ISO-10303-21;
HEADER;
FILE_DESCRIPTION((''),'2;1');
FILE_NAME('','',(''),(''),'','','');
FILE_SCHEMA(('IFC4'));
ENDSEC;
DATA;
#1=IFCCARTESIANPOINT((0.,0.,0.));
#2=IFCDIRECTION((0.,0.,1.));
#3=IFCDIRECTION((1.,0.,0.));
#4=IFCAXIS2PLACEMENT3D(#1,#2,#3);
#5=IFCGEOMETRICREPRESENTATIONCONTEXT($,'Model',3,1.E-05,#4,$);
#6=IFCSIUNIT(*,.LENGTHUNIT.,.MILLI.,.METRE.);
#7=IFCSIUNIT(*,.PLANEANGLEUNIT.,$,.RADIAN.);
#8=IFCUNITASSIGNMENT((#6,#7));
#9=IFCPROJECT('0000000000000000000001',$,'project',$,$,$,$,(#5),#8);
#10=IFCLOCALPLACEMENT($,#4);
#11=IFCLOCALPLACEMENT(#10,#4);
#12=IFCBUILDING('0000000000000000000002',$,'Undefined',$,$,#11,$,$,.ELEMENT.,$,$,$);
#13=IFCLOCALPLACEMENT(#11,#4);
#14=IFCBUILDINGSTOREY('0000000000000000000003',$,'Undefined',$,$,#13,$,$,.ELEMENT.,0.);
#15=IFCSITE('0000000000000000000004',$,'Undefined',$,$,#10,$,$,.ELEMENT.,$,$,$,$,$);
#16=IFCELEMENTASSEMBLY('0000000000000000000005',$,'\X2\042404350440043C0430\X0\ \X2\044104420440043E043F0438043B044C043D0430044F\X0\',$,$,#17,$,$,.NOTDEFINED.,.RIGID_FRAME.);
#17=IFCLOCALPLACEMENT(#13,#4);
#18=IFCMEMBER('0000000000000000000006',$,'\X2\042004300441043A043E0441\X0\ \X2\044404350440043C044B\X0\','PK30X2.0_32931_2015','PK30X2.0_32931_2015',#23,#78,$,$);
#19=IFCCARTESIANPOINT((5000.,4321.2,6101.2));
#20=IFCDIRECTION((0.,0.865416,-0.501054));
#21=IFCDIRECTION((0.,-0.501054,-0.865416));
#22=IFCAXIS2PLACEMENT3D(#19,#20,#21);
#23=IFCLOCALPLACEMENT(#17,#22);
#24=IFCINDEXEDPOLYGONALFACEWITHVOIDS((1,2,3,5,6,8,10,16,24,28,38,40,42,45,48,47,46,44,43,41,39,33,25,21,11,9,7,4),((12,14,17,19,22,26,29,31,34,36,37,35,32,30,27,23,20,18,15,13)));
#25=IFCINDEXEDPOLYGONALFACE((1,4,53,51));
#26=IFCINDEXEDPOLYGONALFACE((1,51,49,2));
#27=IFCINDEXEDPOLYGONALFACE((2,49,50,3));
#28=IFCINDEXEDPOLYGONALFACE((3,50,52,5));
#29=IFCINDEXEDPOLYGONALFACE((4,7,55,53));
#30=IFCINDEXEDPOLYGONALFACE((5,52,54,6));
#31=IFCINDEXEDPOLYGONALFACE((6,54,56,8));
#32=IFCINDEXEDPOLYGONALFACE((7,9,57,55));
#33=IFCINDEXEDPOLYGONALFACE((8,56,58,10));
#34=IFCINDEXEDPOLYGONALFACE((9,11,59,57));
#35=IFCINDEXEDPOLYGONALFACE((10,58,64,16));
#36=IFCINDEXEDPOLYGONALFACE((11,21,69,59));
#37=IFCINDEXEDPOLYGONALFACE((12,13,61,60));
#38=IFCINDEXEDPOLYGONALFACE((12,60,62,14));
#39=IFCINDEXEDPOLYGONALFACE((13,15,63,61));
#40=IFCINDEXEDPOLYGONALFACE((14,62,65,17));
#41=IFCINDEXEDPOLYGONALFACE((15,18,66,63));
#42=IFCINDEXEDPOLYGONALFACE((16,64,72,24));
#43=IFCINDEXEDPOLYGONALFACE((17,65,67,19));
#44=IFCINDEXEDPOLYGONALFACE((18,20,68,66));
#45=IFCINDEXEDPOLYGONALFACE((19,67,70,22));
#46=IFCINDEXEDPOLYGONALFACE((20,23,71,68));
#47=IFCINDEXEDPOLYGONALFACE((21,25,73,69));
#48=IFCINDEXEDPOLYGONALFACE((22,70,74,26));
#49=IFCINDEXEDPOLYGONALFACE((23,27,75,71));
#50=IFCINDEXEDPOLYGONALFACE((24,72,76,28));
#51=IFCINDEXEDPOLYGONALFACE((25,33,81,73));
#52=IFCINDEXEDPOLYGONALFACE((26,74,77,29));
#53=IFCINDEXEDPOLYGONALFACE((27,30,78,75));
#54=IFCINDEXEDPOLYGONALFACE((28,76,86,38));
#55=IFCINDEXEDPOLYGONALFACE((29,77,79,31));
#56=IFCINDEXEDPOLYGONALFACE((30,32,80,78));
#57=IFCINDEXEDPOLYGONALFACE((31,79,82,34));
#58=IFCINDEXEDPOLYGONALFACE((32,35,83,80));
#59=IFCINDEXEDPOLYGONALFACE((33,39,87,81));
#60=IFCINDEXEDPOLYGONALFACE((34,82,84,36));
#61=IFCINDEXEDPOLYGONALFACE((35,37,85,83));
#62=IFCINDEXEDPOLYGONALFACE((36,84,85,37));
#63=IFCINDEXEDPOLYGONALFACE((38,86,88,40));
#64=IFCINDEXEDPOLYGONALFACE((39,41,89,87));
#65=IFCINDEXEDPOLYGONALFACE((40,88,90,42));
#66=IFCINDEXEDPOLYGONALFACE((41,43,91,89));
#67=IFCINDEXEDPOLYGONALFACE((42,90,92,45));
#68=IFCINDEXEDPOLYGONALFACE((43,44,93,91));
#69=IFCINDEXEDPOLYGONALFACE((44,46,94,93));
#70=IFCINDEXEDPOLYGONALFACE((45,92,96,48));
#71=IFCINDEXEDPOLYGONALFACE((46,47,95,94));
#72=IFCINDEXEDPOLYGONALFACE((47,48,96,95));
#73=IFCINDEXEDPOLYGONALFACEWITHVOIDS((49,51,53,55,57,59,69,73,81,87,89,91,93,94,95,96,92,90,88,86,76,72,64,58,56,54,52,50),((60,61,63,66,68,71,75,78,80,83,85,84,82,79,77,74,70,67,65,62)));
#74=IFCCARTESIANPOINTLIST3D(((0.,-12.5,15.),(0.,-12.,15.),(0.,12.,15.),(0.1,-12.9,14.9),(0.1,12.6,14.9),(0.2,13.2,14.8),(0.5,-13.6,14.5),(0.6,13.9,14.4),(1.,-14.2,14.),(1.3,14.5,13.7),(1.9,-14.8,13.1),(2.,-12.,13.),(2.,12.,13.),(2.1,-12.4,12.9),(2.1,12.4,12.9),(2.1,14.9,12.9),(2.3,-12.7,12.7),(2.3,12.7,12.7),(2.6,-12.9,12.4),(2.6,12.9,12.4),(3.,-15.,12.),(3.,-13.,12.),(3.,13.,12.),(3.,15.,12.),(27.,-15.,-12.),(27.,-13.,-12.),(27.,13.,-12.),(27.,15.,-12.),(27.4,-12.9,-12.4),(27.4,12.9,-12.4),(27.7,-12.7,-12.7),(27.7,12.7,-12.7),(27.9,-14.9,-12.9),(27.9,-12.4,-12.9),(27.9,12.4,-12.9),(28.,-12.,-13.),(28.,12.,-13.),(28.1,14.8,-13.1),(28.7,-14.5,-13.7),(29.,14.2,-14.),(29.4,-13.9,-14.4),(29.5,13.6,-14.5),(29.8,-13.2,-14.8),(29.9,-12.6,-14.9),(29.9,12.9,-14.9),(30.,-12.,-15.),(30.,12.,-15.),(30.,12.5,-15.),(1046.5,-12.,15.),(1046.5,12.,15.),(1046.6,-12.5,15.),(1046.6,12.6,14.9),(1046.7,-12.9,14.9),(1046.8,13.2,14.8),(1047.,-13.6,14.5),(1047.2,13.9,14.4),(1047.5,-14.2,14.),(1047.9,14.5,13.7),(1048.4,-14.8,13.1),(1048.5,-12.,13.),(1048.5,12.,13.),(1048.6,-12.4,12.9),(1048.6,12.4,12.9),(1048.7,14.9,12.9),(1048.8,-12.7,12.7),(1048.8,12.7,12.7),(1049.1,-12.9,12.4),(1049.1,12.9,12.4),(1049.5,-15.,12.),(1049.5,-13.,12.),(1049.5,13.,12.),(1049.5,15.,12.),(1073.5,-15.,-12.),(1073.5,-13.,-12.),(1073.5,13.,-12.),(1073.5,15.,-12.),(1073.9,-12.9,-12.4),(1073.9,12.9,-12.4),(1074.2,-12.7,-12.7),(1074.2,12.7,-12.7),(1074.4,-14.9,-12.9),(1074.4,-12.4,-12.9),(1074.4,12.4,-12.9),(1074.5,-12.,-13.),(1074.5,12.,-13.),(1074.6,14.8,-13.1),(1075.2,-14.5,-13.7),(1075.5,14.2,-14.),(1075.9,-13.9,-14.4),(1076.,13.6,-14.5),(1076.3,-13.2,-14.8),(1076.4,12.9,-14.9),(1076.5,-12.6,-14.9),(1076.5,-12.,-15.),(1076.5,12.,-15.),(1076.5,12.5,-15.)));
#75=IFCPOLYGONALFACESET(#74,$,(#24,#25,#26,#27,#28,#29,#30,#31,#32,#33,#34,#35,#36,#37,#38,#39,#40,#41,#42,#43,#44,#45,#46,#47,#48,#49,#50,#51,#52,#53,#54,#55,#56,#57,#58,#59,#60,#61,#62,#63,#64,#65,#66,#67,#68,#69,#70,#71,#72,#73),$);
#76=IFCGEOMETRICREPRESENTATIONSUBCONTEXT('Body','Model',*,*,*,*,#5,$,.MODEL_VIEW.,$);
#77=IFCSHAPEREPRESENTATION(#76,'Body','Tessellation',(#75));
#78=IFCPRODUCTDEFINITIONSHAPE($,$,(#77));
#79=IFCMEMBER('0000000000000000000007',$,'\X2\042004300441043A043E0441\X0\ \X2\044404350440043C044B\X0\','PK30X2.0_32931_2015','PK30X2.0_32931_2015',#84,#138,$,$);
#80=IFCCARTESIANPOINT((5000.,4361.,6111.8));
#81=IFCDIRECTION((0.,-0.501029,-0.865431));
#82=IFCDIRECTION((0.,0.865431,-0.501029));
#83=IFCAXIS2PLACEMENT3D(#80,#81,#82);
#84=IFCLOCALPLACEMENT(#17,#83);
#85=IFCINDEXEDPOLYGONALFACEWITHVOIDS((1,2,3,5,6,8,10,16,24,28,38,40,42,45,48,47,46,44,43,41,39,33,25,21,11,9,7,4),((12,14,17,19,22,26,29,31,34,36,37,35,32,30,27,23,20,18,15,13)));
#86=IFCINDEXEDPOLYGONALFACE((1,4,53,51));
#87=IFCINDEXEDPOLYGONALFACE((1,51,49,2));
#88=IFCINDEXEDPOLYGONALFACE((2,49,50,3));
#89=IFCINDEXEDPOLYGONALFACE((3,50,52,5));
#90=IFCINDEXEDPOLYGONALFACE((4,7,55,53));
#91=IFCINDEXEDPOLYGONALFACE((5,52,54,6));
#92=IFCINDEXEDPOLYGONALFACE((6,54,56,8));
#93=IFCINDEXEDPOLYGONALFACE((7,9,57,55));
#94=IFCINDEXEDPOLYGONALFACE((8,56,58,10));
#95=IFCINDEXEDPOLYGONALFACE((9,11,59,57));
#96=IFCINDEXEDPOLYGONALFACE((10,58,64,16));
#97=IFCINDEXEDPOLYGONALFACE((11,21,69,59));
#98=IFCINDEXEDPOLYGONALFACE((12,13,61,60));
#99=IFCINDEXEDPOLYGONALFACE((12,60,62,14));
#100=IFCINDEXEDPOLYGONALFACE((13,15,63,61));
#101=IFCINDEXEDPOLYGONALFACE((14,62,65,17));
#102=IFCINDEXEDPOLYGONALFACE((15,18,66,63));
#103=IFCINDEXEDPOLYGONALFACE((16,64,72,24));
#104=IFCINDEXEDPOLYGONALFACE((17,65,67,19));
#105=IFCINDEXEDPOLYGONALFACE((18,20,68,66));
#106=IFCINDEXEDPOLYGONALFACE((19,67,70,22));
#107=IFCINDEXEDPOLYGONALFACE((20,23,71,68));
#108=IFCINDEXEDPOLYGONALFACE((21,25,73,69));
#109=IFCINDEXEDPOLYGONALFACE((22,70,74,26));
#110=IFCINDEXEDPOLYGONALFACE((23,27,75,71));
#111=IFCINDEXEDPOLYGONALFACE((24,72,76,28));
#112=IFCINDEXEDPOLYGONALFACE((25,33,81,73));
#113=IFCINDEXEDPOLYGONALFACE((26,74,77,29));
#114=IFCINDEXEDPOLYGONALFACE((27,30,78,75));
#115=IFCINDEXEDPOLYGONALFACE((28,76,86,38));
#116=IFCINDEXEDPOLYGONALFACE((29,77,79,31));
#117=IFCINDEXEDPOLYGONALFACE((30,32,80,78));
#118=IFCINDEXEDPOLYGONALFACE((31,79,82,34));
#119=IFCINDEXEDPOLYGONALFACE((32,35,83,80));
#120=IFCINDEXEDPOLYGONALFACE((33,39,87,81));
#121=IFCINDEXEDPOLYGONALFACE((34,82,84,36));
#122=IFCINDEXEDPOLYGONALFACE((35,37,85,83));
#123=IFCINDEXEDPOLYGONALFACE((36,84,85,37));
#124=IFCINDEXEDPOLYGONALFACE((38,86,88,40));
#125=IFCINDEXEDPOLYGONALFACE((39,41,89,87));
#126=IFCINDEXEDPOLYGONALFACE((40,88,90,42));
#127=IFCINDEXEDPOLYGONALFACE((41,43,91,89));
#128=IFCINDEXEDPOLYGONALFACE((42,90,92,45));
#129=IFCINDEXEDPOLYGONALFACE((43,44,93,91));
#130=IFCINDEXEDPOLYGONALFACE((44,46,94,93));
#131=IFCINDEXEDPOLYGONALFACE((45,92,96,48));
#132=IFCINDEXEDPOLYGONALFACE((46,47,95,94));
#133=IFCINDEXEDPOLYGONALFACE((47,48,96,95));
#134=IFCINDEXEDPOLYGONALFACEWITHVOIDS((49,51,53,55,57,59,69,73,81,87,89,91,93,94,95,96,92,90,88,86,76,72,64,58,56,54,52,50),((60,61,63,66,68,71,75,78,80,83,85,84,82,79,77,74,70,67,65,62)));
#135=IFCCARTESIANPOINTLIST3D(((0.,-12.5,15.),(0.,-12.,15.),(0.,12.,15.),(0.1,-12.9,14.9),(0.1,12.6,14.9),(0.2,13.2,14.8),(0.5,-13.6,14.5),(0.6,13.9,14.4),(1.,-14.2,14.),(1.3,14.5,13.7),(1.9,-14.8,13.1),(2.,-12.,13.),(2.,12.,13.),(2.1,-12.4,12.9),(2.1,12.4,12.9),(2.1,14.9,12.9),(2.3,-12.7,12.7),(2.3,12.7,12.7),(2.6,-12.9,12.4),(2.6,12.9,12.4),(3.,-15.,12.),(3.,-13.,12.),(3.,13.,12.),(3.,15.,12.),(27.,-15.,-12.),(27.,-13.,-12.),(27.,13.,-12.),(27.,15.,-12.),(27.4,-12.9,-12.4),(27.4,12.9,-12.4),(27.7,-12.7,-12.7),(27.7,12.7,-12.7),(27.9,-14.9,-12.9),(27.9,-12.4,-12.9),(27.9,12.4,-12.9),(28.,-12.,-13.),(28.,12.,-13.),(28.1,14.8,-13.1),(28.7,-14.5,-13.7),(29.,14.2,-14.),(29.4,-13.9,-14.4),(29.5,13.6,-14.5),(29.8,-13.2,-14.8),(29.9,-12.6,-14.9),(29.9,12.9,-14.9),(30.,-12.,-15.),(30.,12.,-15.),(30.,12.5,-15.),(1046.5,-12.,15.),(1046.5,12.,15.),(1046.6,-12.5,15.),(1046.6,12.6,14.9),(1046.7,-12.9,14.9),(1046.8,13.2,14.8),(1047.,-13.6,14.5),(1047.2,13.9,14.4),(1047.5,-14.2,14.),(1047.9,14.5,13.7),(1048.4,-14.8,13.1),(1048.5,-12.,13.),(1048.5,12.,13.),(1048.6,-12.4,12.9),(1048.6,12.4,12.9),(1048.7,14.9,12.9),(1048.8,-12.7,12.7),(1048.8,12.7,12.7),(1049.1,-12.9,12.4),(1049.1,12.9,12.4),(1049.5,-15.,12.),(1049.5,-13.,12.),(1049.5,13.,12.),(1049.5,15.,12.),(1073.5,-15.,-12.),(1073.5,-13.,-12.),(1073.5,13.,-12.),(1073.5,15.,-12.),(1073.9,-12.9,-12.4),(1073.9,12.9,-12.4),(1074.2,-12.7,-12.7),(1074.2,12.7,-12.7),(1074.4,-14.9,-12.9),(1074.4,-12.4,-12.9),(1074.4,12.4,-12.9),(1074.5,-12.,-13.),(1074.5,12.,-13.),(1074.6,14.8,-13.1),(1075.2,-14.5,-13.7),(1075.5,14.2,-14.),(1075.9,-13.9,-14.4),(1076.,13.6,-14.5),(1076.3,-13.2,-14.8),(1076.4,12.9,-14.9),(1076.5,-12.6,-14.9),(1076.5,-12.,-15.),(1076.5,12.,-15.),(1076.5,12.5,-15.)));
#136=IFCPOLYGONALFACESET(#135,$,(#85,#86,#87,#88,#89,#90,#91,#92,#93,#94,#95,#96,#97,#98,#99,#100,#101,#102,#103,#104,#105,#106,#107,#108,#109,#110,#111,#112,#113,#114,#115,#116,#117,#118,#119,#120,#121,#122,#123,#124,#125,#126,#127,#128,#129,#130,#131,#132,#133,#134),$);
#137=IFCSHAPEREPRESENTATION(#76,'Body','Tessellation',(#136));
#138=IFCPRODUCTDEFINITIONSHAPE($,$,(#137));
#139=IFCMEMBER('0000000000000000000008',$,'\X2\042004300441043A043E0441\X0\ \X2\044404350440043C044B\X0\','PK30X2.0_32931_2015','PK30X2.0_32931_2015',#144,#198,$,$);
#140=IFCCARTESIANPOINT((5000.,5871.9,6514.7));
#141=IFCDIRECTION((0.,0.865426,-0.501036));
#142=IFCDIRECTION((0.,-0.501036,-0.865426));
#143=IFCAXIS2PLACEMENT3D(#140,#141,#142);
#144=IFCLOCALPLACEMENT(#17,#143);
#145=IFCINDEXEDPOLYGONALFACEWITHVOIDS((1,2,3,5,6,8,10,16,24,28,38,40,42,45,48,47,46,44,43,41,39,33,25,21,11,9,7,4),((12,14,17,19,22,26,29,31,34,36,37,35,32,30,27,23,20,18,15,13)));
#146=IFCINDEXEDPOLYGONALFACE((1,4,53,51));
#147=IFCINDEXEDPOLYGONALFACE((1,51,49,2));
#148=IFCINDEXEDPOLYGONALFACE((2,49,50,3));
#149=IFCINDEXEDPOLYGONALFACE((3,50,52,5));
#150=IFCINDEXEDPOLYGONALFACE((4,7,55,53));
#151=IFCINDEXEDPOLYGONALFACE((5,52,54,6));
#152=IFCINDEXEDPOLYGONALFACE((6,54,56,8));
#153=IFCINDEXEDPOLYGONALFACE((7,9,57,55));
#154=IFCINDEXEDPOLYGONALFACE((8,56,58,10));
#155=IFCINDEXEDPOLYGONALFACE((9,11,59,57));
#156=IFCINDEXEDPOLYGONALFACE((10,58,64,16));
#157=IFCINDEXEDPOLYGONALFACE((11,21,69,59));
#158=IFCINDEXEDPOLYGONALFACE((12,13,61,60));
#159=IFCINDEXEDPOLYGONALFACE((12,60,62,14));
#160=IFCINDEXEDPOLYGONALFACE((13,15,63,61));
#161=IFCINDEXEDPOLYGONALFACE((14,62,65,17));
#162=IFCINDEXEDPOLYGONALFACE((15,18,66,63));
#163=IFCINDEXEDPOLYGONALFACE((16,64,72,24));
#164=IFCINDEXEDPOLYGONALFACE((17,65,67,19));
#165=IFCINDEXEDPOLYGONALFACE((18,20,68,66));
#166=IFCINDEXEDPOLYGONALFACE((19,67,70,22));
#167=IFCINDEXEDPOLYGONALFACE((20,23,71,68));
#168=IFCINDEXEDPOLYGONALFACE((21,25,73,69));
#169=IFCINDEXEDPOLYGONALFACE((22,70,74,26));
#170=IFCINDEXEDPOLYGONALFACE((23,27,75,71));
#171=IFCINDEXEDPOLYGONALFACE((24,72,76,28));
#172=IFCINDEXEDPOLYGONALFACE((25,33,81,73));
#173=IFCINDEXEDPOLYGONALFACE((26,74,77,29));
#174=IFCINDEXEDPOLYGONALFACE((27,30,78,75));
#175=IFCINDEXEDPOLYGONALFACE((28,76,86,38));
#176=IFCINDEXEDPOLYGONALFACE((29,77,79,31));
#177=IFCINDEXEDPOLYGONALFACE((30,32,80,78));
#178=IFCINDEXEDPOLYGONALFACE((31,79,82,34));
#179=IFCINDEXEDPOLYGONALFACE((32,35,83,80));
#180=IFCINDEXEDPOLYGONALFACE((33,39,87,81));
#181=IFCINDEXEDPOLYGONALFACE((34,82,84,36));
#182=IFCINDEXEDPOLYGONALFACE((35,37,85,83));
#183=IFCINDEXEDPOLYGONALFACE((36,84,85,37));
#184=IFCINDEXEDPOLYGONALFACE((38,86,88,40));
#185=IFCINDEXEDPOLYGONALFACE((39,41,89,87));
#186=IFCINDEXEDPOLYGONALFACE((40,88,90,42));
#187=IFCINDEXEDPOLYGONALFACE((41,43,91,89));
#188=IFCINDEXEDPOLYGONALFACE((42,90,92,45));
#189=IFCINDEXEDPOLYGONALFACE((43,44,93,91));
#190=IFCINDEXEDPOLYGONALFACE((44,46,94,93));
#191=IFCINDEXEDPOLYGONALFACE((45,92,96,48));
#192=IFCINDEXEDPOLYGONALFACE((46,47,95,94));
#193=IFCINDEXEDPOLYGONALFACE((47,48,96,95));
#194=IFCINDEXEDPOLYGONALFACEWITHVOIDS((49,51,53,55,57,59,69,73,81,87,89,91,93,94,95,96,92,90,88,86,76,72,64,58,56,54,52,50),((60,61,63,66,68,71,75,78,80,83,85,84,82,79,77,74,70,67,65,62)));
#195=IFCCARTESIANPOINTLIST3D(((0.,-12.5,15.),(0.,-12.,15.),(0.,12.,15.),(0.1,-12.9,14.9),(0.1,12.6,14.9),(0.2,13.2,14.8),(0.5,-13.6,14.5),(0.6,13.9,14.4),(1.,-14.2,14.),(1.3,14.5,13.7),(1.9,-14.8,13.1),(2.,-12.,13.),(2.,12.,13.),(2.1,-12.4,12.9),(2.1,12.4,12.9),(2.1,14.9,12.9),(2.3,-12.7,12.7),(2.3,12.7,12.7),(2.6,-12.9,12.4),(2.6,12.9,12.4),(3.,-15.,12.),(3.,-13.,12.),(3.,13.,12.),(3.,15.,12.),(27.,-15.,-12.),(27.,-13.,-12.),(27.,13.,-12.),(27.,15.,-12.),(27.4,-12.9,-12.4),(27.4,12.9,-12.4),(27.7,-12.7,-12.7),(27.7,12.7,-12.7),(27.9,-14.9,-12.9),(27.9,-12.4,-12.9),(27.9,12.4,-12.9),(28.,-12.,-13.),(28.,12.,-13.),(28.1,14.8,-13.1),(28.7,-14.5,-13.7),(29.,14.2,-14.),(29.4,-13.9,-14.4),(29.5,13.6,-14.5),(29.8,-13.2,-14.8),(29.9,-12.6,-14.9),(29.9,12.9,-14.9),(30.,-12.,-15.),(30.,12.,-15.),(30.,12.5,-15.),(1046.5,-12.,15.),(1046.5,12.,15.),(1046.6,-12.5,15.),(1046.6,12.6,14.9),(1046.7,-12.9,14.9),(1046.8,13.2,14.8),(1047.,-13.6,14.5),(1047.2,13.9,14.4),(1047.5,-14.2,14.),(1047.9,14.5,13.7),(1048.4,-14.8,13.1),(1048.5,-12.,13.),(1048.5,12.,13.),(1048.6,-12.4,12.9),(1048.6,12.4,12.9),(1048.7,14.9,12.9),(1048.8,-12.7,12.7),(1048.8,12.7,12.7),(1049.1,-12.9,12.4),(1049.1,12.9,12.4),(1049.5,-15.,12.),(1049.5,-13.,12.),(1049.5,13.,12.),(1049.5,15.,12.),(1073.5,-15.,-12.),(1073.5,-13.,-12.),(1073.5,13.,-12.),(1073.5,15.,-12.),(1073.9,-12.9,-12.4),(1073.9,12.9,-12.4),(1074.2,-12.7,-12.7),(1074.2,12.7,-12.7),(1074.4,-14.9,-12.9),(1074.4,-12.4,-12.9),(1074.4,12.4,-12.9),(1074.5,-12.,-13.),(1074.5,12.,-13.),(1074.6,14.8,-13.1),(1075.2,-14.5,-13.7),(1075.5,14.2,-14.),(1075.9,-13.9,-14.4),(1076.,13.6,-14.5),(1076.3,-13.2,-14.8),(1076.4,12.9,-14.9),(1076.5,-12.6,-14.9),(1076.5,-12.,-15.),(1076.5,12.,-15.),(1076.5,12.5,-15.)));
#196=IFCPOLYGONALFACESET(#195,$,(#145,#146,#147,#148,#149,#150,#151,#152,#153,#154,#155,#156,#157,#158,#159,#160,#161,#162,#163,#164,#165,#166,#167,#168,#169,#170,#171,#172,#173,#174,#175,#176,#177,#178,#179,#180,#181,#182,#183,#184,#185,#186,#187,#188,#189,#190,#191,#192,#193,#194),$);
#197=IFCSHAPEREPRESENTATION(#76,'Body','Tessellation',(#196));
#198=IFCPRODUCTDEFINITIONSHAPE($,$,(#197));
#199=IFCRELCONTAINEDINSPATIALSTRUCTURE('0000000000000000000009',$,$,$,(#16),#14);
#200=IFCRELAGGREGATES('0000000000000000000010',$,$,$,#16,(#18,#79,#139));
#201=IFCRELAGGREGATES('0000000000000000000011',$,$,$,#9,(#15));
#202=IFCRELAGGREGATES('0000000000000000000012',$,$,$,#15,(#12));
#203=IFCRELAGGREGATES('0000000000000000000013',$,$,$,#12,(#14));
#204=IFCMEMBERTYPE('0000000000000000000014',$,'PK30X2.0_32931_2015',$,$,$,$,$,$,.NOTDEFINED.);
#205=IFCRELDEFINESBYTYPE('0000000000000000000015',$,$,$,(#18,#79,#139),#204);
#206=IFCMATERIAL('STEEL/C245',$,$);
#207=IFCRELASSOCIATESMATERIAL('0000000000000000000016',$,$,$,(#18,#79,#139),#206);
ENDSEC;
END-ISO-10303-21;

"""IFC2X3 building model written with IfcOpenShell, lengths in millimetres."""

from ifc_helpers import new_model, si_unit, frame, origin_with_axes, origin_2d_with_axis, place, context, subcontext, project, spatial, hollow_rectangle, extrude, clip, halfspace, material, type_object, element, aggregate, save


model = new_model("IFC2X3")

# Units and contexts
model_context = context("Model", 3, precision=1e-05, world=origin_with_axes())
body_context = subcontext(model_context, "Body", "Model", "MODEL_VIEW")
ifc_project = project(units=[si_unit("LENGTHUNIT", "METRE", prefix="MILLI"), si_unit("PLANEANGLEUNIT", "RADIAN")], contexts=[model_context])

# Site, building, storey
site_placement = place(None, origin_with_axes())
site = spatial("IfcSite", under=ifc_project, at=site_placement, Name="Undefined", CompositionType="ELEMENT")
building_placement = place(site_placement, origin_with_axes())
building = spatial("IfcBuilding", under=site, at=building_placement, Name="Undefined", CompositionType="ELEMENT")
storey_placement = place(building_placement, origin_with_axes())
storey = spatial("IfcBuildingStorey", under=building, at=storey_placement, Name="Undefined", CompositionType="ELEMENT", Elevation=0.0)

# Element assembly
assembly_1_placement = place(storey_placement, origin_with_axes())
assembly_1 = element("IfcElementAssembly", 1, at=assembly_1_placement, inside=storey, Name="Ферма стропильная", AssemblyPlace="NOTDEFINED", PredefinedType="RIGID_FRAME")
ifc_material_1 = material(Name="STEEL/C245")

# Members
member_type = type_object("IfcMemberType", Name="PK30X2.0_32931_2015", PredefinedType="NOTDEFINED")
member_1_placement = place(assembly_1_placement, frame((5000.0, 4321.2, 6101.2), z_axis=(0.0, 0.865416, -0.501054), x_axis=(0.0, -0.501054, -0.865416)))
member_1 = element("IfcMember", 2, at=member_1_placement, type_object=member_type, material=ifc_material_1, Name="Раскос фермы", Description="PK30X2.0_32931_2015", ObjectType="PK30X2.0_32931_2015", context=body_context, shape_type="Clipping", body=[
    clip(clip(extrude(hollow_rectangle(XDim=30.0, YDim=30.0, WallThickness=2.0, InnerFilletRadius=1.0, OuterFilletRadius=3.0, at=origin_2d_with_axis()), frame((1091.8, 0.0, 0.0), z_axis=(-1.0, 0.0, 0.0), x_axis=(0.0, -1.0, 0.0)), (0.0, 0.0, 1.0), 1107.1), halfspace(frame((1060.0, 0.0, 1.5), z_axis=(-0.707107, 0.0, -0.707107), x_axis=(0.0, -1.0, 0.0)), True)), halfspace(frame((34.5, 0.0, -19.5), z_axis=(-0.707107, 0.0, -0.707107), x_axis=(0.0, -1.0, 0.0)), False)),
])
member_2_placement = place(assembly_1_placement, frame((5000.0, 4361.0, 6111.8), z_axis=(0.0, -0.501029, -0.865431), x_axis=(0.0, 0.865431, -0.501029)))
member_2 = element("IfcMember", 3, at=member_2_placement, type_object=member_type, material=ifc_material_1, Name="Раскос фермы", Description="PK30X2.0_32931_2015", ObjectType="PK30X2.0_32931_2015", context=body_context, shape_type="Clipping", body=[
    clip(clip(extrude(hollow_rectangle(XDim=30.0, YDim=30.0, WallThickness=2.0, InnerFilletRadius=1.0, OuterFilletRadius=3.0, at=origin_2d_with_axis()), frame((1102.9, 0.0, 0.0), z_axis=(-1.0, 0.0, 0.0), x_axis=(0.0, -1.0, 0.0)), (0.0, 0.0, 1.0), 1129.2), halfspace(frame((1060.0, 0.0, 1.5), z_axis=(-0.707107, 0.0, -0.707107), x_axis=(0.0, -1.0, 0.0)), True)), halfspace(frame((34.5, 0.0, -19.5), z_axis=(-0.707107, 0.0, -0.707107), x_axis=(0.0, -1.0, 0.0)), False)),
])
member_3_placement = place(assembly_1_placement, frame((5000.0, 5871.9, 6514.7), z_axis=(0.0, 0.865426, -0.501036), x_axis=(0.0, -0.501036, -0.865426)))
member_3 = element("IfcMember", 4, at=member_3_placement, type_object=member_type, material=ifc_material_1, Name="Раскос фермы", Description="PK30X2.0_32931_2015", ObjectType="PK30X2.0_32931_2015", context=body_context, shape_type="Clipping", body=[
    clip(clip(extrude(hollow_rectangle(XDim=30.0, YDim=30.0, WallThickness=2.0, InnerFilletRadius=1.0, OuterFilletRadius=3.0, at=origin_2d_with_axis()), frame((1091.8, 0.0, 0.0), z_axis=(-1.0, 0.0, 0.0), x_axis=(0.0, -1.0, 0.0)), (0.0, 0.0, 1.0), 1107.1), halfspace(frame((1060.0, 0.0, 1.5), z_axis=(-0.707107, 0.0, -0.707107), x_axis=(0.0, -1.0, 0.0)), True)), halfspace(frame((34.5, 0.0, -19.5), z_axis=(-0.707107, 0.0, -0.707107), x_axis=(0.0, -1.0, 0.0)), False)),
])
aggregate(assembly_1, [member_1, member_2, member_3])

save(model, "model.ifc")
